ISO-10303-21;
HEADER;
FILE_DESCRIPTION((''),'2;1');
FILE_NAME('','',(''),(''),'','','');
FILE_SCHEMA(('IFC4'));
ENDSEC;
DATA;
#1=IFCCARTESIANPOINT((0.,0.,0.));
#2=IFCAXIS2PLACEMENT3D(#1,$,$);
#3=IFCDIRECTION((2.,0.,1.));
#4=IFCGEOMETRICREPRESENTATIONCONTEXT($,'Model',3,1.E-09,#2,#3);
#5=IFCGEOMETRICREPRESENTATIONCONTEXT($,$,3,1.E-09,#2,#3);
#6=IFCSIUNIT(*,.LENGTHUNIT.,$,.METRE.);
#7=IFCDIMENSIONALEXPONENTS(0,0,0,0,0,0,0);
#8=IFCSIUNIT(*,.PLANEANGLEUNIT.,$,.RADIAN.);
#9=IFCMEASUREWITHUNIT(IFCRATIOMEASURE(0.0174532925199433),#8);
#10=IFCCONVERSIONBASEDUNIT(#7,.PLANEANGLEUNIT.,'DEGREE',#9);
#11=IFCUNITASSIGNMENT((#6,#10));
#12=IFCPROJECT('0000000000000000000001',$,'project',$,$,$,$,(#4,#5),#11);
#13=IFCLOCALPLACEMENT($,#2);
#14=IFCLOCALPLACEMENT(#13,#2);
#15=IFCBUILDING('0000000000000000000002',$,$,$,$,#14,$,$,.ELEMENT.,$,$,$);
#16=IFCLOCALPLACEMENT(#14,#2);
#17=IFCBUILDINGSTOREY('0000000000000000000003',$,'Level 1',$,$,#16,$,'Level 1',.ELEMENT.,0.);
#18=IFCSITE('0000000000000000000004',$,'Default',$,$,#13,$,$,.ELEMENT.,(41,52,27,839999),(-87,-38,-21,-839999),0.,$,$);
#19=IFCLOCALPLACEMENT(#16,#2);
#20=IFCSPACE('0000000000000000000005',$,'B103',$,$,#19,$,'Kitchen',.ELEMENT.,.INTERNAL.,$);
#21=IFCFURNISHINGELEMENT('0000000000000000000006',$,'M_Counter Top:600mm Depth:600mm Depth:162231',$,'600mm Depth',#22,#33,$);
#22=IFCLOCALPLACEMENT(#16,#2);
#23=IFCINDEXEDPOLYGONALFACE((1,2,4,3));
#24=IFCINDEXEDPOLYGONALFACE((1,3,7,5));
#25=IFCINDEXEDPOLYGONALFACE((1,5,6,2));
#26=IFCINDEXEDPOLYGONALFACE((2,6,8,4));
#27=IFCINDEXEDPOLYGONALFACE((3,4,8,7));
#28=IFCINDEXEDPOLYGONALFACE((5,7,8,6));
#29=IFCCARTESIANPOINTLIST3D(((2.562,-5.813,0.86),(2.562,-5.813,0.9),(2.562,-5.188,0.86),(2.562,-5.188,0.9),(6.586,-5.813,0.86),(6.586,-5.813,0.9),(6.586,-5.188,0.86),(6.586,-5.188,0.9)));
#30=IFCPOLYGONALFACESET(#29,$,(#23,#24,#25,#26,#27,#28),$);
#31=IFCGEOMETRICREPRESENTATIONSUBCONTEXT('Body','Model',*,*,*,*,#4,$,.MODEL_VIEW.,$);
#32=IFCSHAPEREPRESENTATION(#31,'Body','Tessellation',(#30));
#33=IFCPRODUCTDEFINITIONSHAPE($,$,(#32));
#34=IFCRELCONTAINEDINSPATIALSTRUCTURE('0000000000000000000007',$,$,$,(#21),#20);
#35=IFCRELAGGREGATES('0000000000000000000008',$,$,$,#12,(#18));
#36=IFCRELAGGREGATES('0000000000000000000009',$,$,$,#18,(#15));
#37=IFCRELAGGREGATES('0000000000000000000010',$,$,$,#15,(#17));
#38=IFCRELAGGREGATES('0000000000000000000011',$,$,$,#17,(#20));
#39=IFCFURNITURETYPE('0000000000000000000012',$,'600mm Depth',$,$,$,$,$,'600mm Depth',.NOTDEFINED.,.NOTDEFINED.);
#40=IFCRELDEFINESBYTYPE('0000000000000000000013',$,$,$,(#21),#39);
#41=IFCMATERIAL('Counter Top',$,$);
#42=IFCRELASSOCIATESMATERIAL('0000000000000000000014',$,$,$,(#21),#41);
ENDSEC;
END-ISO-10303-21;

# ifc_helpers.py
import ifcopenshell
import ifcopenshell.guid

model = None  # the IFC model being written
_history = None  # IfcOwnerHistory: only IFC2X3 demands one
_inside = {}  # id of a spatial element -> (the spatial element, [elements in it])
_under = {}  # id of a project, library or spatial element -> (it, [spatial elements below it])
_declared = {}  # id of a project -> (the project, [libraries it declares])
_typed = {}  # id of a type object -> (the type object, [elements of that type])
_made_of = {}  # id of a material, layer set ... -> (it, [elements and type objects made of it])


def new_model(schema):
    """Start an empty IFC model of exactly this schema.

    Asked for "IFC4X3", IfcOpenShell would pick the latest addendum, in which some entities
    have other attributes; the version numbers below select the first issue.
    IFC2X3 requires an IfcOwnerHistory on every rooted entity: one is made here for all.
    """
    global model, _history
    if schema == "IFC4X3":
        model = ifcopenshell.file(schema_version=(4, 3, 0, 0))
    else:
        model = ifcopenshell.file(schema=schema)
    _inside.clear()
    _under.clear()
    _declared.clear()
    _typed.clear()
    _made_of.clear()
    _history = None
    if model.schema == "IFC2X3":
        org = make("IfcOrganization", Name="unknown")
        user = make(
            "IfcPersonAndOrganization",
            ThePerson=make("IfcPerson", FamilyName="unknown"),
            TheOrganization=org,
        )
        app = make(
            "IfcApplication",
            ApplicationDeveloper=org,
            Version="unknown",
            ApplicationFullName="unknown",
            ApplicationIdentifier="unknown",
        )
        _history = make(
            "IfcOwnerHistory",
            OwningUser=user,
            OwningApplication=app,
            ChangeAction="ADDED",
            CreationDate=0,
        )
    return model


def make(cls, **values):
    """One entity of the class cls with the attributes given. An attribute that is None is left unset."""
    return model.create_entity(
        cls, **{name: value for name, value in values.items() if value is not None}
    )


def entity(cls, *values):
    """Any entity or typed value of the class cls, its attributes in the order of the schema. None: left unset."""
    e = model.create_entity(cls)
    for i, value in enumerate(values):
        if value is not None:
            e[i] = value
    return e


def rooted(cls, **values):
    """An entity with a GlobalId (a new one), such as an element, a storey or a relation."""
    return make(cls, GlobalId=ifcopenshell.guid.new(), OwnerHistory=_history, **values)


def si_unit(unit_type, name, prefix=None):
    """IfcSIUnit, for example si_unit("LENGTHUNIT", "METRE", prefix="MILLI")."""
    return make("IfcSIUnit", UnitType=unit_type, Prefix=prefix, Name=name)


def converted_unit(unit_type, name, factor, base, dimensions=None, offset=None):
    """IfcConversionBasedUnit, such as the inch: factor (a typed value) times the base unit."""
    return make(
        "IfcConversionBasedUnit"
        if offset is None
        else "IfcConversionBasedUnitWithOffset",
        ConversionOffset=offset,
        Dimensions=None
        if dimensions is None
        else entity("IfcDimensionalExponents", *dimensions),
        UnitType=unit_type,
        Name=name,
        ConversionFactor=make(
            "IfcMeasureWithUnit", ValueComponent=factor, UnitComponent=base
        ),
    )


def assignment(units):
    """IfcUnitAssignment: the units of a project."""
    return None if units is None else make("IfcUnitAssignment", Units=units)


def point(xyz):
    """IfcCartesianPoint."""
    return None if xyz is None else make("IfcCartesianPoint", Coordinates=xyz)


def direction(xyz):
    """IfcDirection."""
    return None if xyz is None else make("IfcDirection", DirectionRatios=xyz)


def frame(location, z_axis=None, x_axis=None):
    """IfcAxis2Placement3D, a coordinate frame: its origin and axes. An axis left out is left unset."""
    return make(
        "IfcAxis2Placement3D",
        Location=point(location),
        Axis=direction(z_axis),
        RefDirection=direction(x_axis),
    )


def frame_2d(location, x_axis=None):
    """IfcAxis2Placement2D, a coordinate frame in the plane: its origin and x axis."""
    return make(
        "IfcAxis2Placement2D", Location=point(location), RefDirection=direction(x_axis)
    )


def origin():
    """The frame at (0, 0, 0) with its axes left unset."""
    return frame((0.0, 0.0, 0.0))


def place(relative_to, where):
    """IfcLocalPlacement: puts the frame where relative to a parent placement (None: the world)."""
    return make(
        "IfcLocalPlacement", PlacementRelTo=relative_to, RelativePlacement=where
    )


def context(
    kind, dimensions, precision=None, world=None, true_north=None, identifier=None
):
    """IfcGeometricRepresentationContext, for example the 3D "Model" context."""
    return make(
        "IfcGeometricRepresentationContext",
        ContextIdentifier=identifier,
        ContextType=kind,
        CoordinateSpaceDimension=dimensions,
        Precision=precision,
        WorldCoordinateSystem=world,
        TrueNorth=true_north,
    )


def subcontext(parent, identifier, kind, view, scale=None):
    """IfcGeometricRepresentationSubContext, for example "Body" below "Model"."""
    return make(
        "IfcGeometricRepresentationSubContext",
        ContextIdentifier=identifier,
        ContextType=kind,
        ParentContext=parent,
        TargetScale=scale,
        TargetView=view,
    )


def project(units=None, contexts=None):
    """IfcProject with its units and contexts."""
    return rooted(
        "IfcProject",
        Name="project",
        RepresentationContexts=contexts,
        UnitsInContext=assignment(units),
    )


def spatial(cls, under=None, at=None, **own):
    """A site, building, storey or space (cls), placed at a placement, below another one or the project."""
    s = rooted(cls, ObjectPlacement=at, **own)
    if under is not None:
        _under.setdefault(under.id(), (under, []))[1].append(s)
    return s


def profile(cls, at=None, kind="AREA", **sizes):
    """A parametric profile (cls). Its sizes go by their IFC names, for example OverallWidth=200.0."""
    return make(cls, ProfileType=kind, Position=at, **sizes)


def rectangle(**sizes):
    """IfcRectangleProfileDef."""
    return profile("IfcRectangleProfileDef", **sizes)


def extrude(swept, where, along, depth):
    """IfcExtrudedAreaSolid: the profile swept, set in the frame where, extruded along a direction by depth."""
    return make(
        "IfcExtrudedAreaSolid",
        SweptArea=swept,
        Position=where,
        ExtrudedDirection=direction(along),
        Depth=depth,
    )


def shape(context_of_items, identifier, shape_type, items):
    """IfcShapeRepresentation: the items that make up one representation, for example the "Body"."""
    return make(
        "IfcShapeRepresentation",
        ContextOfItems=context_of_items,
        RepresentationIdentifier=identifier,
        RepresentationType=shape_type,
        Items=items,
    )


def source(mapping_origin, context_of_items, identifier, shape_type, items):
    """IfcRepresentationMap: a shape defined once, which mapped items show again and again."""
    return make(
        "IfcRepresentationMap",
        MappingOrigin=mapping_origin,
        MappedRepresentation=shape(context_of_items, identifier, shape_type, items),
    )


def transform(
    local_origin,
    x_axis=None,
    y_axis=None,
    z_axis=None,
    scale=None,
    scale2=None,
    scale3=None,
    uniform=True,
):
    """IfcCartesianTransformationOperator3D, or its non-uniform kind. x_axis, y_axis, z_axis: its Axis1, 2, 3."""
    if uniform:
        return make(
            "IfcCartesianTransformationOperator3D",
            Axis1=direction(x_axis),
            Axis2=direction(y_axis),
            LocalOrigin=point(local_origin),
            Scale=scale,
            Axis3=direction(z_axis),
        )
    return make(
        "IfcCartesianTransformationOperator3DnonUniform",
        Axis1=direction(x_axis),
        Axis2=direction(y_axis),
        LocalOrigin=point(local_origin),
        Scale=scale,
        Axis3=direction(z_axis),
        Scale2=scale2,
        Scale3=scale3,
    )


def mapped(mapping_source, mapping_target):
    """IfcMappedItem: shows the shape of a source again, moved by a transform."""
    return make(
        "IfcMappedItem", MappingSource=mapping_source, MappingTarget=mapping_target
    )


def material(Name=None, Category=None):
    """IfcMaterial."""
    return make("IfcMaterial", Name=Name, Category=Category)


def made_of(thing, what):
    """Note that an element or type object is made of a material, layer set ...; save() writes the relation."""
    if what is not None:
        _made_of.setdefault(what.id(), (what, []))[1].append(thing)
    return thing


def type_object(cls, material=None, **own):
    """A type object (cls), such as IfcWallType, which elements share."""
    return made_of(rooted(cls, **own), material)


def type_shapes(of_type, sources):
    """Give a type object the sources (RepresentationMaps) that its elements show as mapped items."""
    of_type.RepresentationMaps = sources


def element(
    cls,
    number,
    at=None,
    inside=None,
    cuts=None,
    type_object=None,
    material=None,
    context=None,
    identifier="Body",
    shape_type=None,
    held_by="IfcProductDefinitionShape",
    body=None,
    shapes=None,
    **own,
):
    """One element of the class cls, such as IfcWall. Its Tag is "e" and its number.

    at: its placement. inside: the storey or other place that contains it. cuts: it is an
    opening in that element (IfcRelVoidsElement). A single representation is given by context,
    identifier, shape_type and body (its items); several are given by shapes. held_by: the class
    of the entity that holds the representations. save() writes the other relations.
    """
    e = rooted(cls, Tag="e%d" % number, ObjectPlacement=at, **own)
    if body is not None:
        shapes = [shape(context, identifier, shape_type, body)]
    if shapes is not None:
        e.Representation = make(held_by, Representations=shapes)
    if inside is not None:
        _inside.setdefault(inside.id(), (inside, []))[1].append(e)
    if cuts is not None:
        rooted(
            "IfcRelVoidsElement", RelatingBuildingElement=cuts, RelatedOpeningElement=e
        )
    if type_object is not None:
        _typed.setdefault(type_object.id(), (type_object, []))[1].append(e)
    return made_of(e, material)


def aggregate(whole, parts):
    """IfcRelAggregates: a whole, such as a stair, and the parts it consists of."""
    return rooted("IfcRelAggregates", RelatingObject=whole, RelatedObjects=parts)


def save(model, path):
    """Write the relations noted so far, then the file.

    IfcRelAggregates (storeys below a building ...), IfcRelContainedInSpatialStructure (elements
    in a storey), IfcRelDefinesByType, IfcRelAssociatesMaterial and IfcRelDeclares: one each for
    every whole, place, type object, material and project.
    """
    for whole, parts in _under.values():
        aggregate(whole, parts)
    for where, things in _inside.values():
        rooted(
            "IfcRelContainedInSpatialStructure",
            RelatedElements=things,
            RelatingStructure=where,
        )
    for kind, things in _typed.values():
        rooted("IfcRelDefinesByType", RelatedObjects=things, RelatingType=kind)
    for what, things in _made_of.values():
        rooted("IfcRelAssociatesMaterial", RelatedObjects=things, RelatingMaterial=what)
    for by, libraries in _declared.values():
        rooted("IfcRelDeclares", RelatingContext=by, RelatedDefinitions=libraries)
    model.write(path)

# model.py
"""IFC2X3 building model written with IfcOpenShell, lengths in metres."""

from ifc_helpers import new_model, entity, si_unit, converted_unit, direction, frame, frame_2d, origin, place, context, subcontext, project, spatial, rectangle, extrude, source, transform, mapped, material, type_object, type_shapes, element, save


model = new_model("IFC2X3")

# Units and contexts
model_context = context("Model", 3, precision=1e-09, world=origin(), true_north=direction((2.0, 0.0, 1.0)))
context_of_model = context(None, 3, precision=1e-09, world=origin(), true_north=direction((2.0, 0.0, 1.0)))
body_context = subcontext(model_context, "Body", "Model", "MODEL_VIEW")
ifc_project = project(units=[si_unit("LENGTHUNIT", "METRE"), converted_unit("PLANEANGLEUNIT", "DEGREE", entity("IfcRatioMeasure", 0.0174532925199433), si_unit("PLANEANGLEUNIT", "RADIAN"), dimensions=[0, 0, 0, 0, 0, 0, 0])], contexts=[model_context, context_of_model])

# Site, building, storey
site_placement = place(None, origin())
site = spatial("IfcSite", under=ifc_project, at=site_placement, Name="Default", CompositionType="ELEMENT", RefLatitude=(41, 52, 27, 839999), RefLongitude=(-87, -38, -21, -839999), RefElevation=0.0)
building_placement = place(site_placement, origin())
building = spatial("IfcBuilding", under=site, at=building_placement, CompositionType="ELEMENT")
storey_placement = place(building_placement, origin())
storey = spatial("IfcBuildingStorey", under=building, at=storey_placement, Name="Level 1", LongName="Level 1", CompositionType="ELEMENT", Elevation=0.0)

# Shared definitions
space_1_placement = place(storey_placement, origin())
space_1 = spatial("IfcSpace", under=storey, at=space_1_placement, Name="B103", LongName="Kitchen", CompositionType="ELEMENT", InteriorOrExteriorSpace="INTERNAL")

# Shared definitions
ifc_material_1 = material(Name="Counter Top")

# Furnishing element
furniture_type_1 = type_object("IfcFurnitureType", Name="600mm Depth", ElementType="600mm Depth", AssemblyPlace="NOTDEFINED")
shared_shape_1 = source(origin(), body_context, "Body", "SweptSolid", [
    extrude(rectangle(XDim=4.024, YDim=0.625, at=frame_2d((0.0, 0.0), x_axis=(1.0, 0.0))), frame((0.8115, -0.3125, 0.86), z_axis=(0.0, 0.0, 1.0), x_axis=(-1.0, 0.0, 0.0)), (0.0, 0.0, 1.0), 0.04),
])
type_shapes(furniture_type_1, [shared_shape_1])
furnishing_1_placement = place(space_1_placement, frame((3.7625, -5.188, 0.0)))
element("IfcFurnishingElement", 1, at=furnishing_1_placement, inside=space_1, type_object=furniture_type_1, material=ifc_material_1, Name="M_Counter Top:600mm Depth:600mm Depth:162231", ObjectType="600mm Depth", context=body_context, shape_type="MappedRepresentation", body=[
    mapped(shared_shape_1, transform((0.0, 0.0, 0.0), scale=1.0)),
])

save(model, "model.ifc")
